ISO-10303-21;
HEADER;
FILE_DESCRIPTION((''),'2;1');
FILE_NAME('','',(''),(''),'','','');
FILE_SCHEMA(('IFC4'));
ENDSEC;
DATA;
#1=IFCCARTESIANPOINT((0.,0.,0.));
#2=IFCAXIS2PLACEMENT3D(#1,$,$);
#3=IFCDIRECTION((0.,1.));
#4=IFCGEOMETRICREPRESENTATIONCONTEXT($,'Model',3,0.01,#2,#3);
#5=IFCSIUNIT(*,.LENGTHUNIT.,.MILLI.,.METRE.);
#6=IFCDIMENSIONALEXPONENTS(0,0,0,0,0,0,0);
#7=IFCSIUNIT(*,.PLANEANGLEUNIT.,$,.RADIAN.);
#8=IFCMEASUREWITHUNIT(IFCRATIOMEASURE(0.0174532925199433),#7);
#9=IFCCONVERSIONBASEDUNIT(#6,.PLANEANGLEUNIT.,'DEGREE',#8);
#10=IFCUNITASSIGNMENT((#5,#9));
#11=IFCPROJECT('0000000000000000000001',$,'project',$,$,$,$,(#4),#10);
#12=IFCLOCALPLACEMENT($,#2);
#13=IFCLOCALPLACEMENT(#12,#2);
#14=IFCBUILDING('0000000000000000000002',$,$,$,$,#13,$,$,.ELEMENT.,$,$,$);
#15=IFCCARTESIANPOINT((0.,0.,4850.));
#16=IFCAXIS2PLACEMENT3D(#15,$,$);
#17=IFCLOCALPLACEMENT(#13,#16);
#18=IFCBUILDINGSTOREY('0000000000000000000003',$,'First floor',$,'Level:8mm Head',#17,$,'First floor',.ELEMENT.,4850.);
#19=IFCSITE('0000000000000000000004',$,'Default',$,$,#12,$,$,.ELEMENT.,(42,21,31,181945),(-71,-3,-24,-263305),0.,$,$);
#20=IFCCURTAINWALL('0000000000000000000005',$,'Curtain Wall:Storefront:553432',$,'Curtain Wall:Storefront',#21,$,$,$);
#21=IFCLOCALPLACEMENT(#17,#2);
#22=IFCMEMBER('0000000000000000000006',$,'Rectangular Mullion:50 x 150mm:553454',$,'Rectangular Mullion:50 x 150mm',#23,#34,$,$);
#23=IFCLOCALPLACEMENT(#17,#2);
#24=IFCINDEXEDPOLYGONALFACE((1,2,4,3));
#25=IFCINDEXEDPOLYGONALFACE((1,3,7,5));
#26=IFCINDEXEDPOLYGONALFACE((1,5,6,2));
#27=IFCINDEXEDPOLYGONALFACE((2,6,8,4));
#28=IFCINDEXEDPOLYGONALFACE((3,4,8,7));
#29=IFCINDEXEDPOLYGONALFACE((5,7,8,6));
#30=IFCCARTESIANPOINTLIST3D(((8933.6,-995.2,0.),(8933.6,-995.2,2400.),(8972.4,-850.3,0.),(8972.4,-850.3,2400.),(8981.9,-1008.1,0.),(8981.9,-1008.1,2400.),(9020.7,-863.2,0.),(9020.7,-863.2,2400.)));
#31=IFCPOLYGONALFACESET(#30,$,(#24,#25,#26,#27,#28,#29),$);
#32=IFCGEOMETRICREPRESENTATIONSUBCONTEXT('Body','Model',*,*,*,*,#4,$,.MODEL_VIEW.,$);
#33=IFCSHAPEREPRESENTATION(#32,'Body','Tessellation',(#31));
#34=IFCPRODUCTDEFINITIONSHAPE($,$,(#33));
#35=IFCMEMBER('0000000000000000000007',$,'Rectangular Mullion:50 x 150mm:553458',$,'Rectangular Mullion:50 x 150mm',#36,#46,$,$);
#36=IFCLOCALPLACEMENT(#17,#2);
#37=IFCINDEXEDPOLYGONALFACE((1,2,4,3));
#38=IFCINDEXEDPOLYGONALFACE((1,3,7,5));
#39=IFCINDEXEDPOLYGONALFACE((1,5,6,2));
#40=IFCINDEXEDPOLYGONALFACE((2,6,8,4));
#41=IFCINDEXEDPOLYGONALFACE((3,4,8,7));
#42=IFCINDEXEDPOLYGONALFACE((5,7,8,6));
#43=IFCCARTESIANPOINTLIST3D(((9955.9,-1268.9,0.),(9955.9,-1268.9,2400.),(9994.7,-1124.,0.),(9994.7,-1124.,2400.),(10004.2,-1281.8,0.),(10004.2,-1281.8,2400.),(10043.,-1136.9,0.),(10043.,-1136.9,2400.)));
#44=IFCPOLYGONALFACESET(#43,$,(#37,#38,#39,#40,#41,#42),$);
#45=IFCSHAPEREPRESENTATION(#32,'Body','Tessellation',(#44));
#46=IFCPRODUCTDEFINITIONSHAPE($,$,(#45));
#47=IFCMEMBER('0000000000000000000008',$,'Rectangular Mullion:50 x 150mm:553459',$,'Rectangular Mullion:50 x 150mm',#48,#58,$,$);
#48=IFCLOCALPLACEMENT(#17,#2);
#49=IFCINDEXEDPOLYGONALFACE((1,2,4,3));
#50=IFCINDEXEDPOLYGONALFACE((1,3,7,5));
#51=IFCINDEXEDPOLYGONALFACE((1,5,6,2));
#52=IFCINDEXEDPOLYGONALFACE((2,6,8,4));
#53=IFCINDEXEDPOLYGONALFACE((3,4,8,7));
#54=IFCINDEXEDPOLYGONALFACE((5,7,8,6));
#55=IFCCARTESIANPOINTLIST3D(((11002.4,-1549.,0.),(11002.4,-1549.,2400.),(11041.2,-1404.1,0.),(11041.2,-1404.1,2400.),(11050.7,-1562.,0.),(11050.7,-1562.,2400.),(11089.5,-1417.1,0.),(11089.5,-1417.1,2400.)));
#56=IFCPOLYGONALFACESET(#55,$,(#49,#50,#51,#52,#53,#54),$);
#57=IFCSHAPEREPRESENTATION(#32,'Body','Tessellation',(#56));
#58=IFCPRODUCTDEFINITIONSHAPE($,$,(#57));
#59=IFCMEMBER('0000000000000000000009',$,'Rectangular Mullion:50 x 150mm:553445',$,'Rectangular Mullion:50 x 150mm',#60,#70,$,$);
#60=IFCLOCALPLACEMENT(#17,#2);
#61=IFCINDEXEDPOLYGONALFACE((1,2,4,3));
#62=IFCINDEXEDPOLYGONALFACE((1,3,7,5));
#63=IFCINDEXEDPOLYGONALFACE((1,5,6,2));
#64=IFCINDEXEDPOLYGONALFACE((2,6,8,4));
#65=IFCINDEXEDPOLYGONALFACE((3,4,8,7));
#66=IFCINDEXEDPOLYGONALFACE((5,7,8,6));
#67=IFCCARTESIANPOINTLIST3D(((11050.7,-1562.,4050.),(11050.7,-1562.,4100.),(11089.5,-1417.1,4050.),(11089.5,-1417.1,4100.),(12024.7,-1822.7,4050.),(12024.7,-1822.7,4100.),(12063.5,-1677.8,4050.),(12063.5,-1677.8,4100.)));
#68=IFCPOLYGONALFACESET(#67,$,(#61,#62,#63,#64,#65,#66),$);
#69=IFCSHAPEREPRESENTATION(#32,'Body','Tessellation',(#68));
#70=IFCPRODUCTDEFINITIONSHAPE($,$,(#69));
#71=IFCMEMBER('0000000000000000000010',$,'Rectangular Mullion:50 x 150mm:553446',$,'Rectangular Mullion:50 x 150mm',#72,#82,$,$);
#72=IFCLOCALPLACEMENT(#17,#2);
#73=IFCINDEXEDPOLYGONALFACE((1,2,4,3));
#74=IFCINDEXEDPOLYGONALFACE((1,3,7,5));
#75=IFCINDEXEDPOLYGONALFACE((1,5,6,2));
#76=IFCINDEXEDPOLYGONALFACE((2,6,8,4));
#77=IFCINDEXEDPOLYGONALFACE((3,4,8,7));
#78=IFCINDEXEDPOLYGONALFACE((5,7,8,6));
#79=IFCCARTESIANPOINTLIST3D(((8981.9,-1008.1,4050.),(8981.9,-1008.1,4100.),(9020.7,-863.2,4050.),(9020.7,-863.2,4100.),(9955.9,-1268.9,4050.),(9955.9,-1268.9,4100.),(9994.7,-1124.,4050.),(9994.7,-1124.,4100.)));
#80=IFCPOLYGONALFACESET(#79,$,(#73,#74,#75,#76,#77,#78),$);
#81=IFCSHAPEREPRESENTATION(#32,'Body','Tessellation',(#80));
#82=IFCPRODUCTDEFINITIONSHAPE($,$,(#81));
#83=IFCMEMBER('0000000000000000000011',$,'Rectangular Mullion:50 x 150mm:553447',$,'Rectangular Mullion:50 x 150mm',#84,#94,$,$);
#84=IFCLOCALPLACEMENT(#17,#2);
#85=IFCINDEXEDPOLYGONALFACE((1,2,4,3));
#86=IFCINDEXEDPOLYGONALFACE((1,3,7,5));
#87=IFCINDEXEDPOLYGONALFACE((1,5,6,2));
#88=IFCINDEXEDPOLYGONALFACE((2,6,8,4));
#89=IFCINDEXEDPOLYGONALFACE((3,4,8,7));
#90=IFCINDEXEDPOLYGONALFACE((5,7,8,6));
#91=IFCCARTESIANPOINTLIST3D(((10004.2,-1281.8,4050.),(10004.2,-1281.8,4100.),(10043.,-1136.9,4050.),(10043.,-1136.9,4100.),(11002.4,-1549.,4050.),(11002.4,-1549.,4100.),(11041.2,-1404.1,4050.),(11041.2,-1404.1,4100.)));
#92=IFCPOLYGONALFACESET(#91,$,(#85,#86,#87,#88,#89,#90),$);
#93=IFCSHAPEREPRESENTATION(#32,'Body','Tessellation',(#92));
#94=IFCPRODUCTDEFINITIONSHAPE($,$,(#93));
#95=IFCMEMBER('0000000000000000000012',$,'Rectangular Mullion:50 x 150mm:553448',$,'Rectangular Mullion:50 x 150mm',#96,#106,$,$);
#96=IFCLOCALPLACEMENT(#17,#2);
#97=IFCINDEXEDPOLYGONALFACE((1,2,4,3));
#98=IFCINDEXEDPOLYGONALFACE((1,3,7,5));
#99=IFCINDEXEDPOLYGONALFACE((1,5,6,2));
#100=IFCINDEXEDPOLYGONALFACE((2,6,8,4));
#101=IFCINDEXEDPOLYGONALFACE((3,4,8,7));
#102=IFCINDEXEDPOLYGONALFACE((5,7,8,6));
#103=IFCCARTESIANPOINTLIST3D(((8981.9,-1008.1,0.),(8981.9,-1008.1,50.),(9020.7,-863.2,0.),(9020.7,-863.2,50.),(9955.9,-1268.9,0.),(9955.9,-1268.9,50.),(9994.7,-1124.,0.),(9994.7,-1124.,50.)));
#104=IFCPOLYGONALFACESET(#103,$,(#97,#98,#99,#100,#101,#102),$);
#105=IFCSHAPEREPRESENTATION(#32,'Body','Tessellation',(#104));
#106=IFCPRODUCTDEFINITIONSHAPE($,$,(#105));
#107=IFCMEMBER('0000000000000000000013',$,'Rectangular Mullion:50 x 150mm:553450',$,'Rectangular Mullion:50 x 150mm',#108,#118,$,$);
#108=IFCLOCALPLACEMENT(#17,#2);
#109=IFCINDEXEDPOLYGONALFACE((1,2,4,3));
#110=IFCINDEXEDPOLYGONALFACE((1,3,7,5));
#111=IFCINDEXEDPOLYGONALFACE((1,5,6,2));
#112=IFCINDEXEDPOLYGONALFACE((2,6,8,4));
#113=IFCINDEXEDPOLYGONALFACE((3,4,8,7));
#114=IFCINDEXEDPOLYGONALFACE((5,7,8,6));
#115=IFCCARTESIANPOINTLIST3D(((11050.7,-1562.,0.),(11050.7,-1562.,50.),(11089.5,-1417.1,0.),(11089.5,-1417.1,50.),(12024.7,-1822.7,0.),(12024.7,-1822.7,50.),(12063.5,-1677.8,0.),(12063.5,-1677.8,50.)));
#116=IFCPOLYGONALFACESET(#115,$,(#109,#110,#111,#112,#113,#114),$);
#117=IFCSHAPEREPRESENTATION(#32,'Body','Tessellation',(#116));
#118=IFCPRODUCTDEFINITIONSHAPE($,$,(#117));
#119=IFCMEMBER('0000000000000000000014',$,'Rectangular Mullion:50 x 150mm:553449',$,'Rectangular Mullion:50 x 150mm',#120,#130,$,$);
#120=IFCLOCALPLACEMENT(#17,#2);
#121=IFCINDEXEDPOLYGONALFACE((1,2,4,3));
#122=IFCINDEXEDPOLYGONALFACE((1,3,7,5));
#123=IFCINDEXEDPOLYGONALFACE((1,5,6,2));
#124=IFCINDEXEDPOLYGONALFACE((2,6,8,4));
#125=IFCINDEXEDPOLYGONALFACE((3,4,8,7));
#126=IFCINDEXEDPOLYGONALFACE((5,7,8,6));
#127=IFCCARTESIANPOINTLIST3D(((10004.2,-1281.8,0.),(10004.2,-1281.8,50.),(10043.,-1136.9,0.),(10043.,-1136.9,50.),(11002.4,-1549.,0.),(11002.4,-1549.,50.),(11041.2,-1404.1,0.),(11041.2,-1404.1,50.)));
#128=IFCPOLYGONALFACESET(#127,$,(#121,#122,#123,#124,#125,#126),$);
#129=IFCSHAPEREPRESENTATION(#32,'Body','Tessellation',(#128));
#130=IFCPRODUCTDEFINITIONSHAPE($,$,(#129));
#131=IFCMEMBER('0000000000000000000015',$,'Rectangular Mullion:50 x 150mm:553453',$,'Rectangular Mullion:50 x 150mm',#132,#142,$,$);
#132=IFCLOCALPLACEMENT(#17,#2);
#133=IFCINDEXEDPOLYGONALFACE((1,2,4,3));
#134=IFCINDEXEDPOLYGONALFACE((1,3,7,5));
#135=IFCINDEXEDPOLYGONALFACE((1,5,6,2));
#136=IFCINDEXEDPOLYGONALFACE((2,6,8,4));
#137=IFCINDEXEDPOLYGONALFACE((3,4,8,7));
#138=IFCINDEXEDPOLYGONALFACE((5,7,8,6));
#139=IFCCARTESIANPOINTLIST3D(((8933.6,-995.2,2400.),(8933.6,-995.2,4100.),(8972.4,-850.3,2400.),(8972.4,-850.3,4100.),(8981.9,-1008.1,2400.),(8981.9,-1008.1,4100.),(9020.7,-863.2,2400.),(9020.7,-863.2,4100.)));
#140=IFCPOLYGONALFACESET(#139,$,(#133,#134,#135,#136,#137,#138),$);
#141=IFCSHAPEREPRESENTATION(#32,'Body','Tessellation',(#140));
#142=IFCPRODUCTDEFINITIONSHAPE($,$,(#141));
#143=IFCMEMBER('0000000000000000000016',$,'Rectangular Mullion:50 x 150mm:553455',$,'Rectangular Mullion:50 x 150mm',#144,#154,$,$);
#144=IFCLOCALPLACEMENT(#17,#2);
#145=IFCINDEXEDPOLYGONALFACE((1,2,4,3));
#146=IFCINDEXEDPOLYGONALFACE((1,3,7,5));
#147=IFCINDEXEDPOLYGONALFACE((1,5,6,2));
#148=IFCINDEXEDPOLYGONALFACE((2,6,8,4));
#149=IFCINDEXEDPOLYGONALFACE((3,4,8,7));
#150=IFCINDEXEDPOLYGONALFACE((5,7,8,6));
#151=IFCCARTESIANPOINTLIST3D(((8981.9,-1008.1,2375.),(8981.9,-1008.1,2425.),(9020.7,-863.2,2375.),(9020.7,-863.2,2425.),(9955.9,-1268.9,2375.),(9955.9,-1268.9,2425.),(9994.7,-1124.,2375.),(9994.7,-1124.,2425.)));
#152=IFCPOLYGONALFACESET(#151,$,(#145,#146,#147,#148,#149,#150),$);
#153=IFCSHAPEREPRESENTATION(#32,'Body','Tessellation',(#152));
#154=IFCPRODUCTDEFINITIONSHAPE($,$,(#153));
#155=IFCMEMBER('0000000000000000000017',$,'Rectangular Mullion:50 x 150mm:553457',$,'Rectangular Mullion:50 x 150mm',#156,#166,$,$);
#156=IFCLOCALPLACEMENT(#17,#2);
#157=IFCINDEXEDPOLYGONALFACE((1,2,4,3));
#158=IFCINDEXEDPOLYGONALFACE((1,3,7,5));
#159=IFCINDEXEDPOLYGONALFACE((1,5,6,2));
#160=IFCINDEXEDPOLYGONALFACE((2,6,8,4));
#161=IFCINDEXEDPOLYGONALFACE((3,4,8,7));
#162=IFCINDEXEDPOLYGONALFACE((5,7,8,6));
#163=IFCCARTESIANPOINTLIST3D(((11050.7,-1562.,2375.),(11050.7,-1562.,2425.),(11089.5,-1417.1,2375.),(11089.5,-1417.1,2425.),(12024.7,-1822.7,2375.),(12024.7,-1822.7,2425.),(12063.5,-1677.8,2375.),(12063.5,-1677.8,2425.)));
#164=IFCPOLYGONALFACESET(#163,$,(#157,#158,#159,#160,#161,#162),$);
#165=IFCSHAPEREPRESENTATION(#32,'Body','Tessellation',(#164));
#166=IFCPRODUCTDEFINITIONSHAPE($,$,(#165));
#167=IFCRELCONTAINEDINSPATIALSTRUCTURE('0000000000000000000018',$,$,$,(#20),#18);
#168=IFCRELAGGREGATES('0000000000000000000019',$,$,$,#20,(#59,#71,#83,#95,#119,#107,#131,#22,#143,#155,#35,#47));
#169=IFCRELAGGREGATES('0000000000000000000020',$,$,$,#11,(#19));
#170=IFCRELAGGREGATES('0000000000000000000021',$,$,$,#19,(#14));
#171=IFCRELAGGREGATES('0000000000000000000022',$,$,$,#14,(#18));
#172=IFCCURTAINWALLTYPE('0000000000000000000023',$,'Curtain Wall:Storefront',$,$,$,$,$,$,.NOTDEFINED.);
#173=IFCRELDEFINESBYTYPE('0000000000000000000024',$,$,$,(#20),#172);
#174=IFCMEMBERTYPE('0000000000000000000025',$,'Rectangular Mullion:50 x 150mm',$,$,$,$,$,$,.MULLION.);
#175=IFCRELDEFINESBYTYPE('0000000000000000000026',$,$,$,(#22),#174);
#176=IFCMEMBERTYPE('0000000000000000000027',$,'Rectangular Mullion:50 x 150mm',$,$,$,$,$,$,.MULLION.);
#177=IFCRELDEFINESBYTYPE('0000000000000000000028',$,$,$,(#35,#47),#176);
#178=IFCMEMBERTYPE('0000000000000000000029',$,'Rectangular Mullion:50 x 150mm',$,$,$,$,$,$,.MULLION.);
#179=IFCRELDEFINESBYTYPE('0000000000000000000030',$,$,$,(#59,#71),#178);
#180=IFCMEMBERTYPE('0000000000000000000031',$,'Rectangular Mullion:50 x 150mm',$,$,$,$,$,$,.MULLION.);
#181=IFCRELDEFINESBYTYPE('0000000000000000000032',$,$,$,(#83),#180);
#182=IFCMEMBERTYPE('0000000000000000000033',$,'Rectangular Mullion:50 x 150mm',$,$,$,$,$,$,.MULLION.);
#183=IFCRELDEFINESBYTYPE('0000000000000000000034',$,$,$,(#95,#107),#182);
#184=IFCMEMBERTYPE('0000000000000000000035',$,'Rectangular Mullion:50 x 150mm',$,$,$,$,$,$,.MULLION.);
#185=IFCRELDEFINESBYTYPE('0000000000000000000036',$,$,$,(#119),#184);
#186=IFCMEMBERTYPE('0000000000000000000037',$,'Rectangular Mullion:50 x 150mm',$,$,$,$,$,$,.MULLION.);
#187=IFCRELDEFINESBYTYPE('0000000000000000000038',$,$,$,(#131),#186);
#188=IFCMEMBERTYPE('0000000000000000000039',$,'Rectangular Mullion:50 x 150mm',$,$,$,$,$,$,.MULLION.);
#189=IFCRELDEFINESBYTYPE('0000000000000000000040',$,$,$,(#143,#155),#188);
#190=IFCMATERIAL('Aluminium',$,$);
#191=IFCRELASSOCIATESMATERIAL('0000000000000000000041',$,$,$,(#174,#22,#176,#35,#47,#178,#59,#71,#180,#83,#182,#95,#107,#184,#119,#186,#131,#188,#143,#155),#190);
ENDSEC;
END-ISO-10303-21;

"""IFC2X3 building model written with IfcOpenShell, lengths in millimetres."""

from ifc_helpers import new_model, entity, si_unit, converted_unit, direction, frame, frame_2d, origin, origin_2d_with_axis, place, context, subcontext, project, spatial, rectangle, extrude, source, transform, mapped, material, type_object, type_shapes, element, aggregate, save


model = new_model("IFC2X3")

# Units and contexts
model_context = context("Model", 3, precision=0.01, world=origin(), true_north=direction((0.0, 1.0)))
body_context = subcontext(model_context, "Body", "Model", "MODEL_VIEW")
ifc_project = project(units=[si_unit("LENGTHUNIT", "METRE", prefix="MILLI"), converted_unit("PLANEANGLEUNIT", "DEGREE", entity("IfcRatioMeasure", 0.0174532925199433), si_unit("PLANEANGLEUNIT", "RADIAN"), dimensions=[0, 0, 0, 0, 0, 0, 0])], contexts=[model_context])

# Site, building, storey
site_placement = place(None, origin())
site = spatial("IfcSite", under=ifc_project, at=site_placement, Name="Default", CompositionType="ELEMENT", RefLatitude=(42, 21, 31, 181945), RefLongitude=(-71, -3, -24, -263305), RefElevation=0.0)
building_placement = place(site_placement, origin())
building = spatial("IfcBuilding", under=site, at=building_placement, CompositionType="ELEMENT")
storey_placement = place(building_placement, frame((0.0, 0.0, 4850.0)))
storey = spatial("IfcBuildingStorey", under=building, at=storey_placement, Name="First floor", ObjectType="Level:8mm Head", LongName="First floor", CompositionType="ELEMENT", Elevation=4850.0)

# Curtain wall, members
curtain_wall_type = type_object("IfcCurtainWallType", Name="Curtain Wall:Storefront", PredefinedType="NOTDEFINED")
curtain_wall_placement = place(storey_placement, frame((0.0, 0.0, -4850.0)))
curtain_wall = element("IfcCurtainWall", 1, at=curtain_wall_placement, inside=storey, type_object=curtain_wall_type, Name="Curtain Wall:Storefront:553432", ObjectType="Curtain Wall:Storefront")
ifc_material_1 = material(Name="Aluminium")
member_type_1 = type_object("IfcMemberType", Name="Rectangular Mullion:50 x 150mm", PredefinedType="MULLION", material=ifc_material_1)
shared_shape_1 = source(origin(), body_context, "Body", "SweptSolid", [
    extrude(rectangle(XDim=150.0, YDim=50.0, at=origin_2d_with_axis()), frame((-25.0, 0.0, -2400.0), z_axis=(0.0, 0.0, 1.0), x_axis=(0.0, -1.0, 0.0)), (0.0, 0.0, 1.0), 2400.0),
])
type_shapes(member_type_1, [shared_shape_1])
member_1_placement = place(storey_placement, frame((8953.0, -922.7, 2400.0), z_axis=(0.0, 0.0, 1.0), x_axis=(-0.965983, 0.258606, 0.0)))
member_1 = element("IfcMember", 2, at=member_1_placement, type_object=member_type_1, material=ifc_material_1, Name="Rectangular Mullion:50 x 150mm:553454", ObjectType="Rectangular Mullion:50 x 150mm", context=body_context, shape_type="MappedRepresentation", body=[
    mapped(shared_shape_1, transform((0.0, 0.0, 0.0), scale=1.0)),
])
member_type_2 = type_object("IfcMemberType", Name="Rectangular Mullion:50 x 150mm", PredefinedType="MULLION", material=ifc_material_1)
shared_shape_2 = source(origin(), body_context, "Body", "SweptSolid", [
    extrude(rectangle(XDim=150.0, YDim=50.0, at=origin_2d_with_axis()), frame((0.0, 0.0, -2400.0), z_axis=(0.0, 0.0, 1.0), x_axis=(0.0, -1.0, 0.0)), (0.0, 0.0, 1.0), 2400.0),
])
type_shapes(member_type_2, [shared_shape_2])
member_2_placement = place(storey_placement, frame((9999.4, -1202.9, 0.0), z_axis=(0.0, 0.0, -1.0), x_axis=(0.965983, -0.258606, 0.0)))
member_2 = element("IfcMember", 3, at=member_2_placement, type_object=member_type_2, material=ifc_material_1, Name="Rectangular Mullion:50 x 150mm:553458", ObjectType="Rectangular Mullion:50 x 150mm", context=body_context, shape_type="MappedRepresentation", body=[
    mapped(shared_shape_2, transform((0.0, 0.0, 0.0), scale=1.0)),
])
member_3_placement = place(storey_placement, frame((11045.9, -1483.1, 0.0), z_axis=(0.0, 0.0, -1.0), x_axis=(0.965983, -0.258606, 0.0)))
member_3 = element("IfcMember", 4, at=member_3_placement, type_object=member_type_2, material=ifc_material_1, Name="Rectangular Mullion:50 x 150mm:553459", ObjectType="Rectangular Mullion:50 x 150mm", context=body_context, shape_type="MappedRepresentation", body=[
    mapped(shared_shape_2, transform((0.0, 0.0, 0.0), scale=1.0)),
])
member_type_3 = type_object("IfcMemberType", Name="Rectangular Mullion:50 x 150mm", PredefinedType="MULLION", material=ifc_material_1)
shared_shape_3 = source(origin(), body_context, "Body", "SweptSolid", [
    extrude(rectangle(XDim=150.0, YDim=50.0, at=origin_2d_with_axis()), frame((-25.0, 0.0, -1008.3), z_axis=(0.0, 0.0, 1.0), x_axis=(0.0, -1.0, 0.0)), (0.0, 0.0, 1.0), 1008.3),
])
type_shapes(member_type_3, [shared_shape_3])
member_4_placement = place(storey_placement, frame((12044.1, -1750.3, 4100.0), z_axis=(0.965983, -0.258606, 0.0), x_axis=(0.0, 0.0, 1.0)))
member_4 = element("IfcMember", 5, at=member_4_placement, type_object=member_type_3, material=ifc_material_1, Name="Rectangular Mullion:50 x 150mm:553445", ObjectType="Rectangular Mullion:50 x 150mm", context=body_context, shape_type="MappedRepresentation", body=[
    mapped(shared_shape_3, transform((0.0, 0.0, 0.0), scale=1.0)),
])
member_5_placement = place(storey_placement, frame((9975.3, -1196.4, 4100.0), z_axis=(0.965983, -0.258606, 0.0), x_axis=(0.0, 0.0, 1.0)))
member_5 = element("IfcMember", 6, at=member_5_placement, type_object=member_type_3, material=ifc_material_1, Name="Rectangular Mullion:50 x 150mm:553446", ObjectType="Rectangular Mullion:50 x 150mm", context=body_context, shape_type="MappedRepresentation", body=[
    mapped(shared_shape_3, transform((0.0, 0.0, 0.0), scale=1.0)),
])
member_type_4 = type_object("IfcMemberType", Name="Rectangular Mullion:50 x 150mm", PredefinedType="MULLION", material=ifc_material_1)
shared_shape_4 = source(origin(), body_context, "Body", "SweptSolid", [
    extrude(rectangle(XDim=150.0, YDim=50.0, at=frame_2d((0.0, 0.0), x_axis=(1.0, 0.0))), frame((-25.0, 0.0, -1033.3), z_axis=(0.0, 0.0, 1.0), x_axis=(0.0, -1.0, 0.0)), (0.0, 0.0, 1.0), 1033.3),
])
type_shapes(member_type_4, [shared_shape_4])
member_6_placement = place(storey_placement, frame((11021.8, -1476.6, 4100.0), z_axis=(0.965983, -0.258606, 0.0), x_axis=(0.0, 0.0, 1.0)))
member_6 = element("IfcMember", 7, at=member_6_placement, type_object=member_type_4, material=ifc_material_1, Name="Rectangular Mullion:50 x 150mm:553447", ObjectType="Rectangular Mullion:50 x 150mm", context=body_context, shape_type="MappedRepresentation", body=[
    mapped(shared_shape_4, transform((0.0, 0.0, 0.0), scale=1.0)),
])
member_type_5 = type_object("IfcMemberType", Name="Rectangular Mullion:50 x 150mm", PredefinedType="MULLION", material=ifc_material_1)
shared_shape_5 = source(origin(), body_context, "Body", "SweptSolid", [
    extrude(rectangle(XDim=150.0, YDim=50.0, at=frame_2d((0.0, 0.0), x_axis=(1.0, 0.0))), frame((-25.0, 0.0, -1008.3), z_axis=(0.0, 0.0, 1.0), x_axis=(0.0, -1.0, 0.0)), (0.0, 0.0, 1.0), 1008.3),
])
type_shapes(member_type_5, [shared_shape_5])
member_7_placement = place(storey_placement, frame((9001.3, -935.7, 0.0), z_axis=(-0.965983, 0.258606, 0.0), x_axis=(0.0, 0.0, -1.0)))
member_7 = element("IfcMember", 8, at=member_7_placement, type_object=member_type_5, material=ifc_material_1, Name="Rectangular Mullion:50 x 150mm:553448", ObjectType="Rectangular Mullion:50 x 150mm", context=body_context, shape_type="MappedRepresentation", body=[
    mapped(shared_shape_5, transform((0.0, 0.0, 0.0), scale=1.0)),
])
member_8_placement = place(storey_placement, frame((11070.1, -1489.5, 0.0), z_axis=(-0.965983, 0.258606, 0.0), x_axis=(0.0, 0.0, -1.0)))
member_8 = element("IfcMember", 9, at=member_8_placement, type_object=member_type_5, material=ifc_material_1, Name="Rectangular Mullion:50 x 150mm:553450", ObjectType="Rectangular Mullion:50 x 150mm", context=body_context, shape_type="MappedRepresentation", body=[
    mapped(shared_shape_5, transform((0.0, 0.0, 0.0), scale=1.0)),
])
member_type_6 = type_object("IfcMemberType", Name="Rectangular Mullion:50 x 150mm", PredefinedType="MULLION", material=ifc_material_1)
shared_shape_6 = source(origin(), body_context, "Body", "SweptSolid", [
    extrude(rectangle(XDim=150.0, YDim=50.0, at=frame_2d((0.0, 0.0), x_axis=(1.0, 0.0))), frame((-25.0, 0.0, -1033.3), z_axis=(0.0, 0.0, 1.0), x_axis=(0.0, -1.0, 0.0)), (0.0, 0.0, 1.0), 1033.3),
])
type_shapes(member_type_6, [shared_shape_6])
member_9_placement = place(storey_placement, frame((10023.6, -1209.4, 0.0), z_axis=(-0.965983, 0.258606, 0.0), x_axis=(0.0, 0.0, -1.0)))
member_9 = element("IfcMember", 10, at=member_9_placement, type_object=member_type_6, material=ifc_material_1, Name="Rectangular Mullion:50 x 150mm:553449", ObjectType="Rectangular Mullion:50 x 150mm", context=body_context, shape_type="MappedRepresentation", body=[
    mapped(shared_shape_6, transform((0.0, 0.0, 0.0), scale=1.0)),
])
member_type_7 = type_object("IfcMemberType", Name="Rectangular Mullion:50 x 150mm", PredefinedType="MULLION", material=ifc_material_1)
shared_shape_7 = source(origin(), body_context, "Body", "SweptSolid", [
    extrude(rectangle(XDim=150.0, YDim=50.0, at=origin_2d_with_axis()), frame((-25.0, 0.0, -1700.0), z_axis=(0.0, 0.0, 1.0), x_axis=(0.0, -1.0, 0.0)), (0.0, 0.0, 1.0), 1700.0),
])
type_shapes(member_type_7, [shared_shape_7])
member_10_placement = place(storey_placement, frame((8953.0, -922.7, 4100.0), z_axis=(0.0, 0.0, 1.0), x_axis=(-0.965983, 0.258606, 0.0)))
member_10 = element("IfcMember", 11, at=member_10_placement, type_object=member_type_7, material=ifc_material_1, Name="Rectangular Mullion:50 x 150mm:553453", ObjectType="Rectangular Mullion:50 x 150mm", context=body_context, shape_type="MappedRepresentation", body=[
    mapped(shared_shape_7, transform((0.0, 0.0, 0.0), scale=1.0)),
])
member_type_8 = type_object("IfcMemberType", Name="Rectangular Mullion:50 x 150mm", PredefinedType="MULLION", material=ifc_material_1)
shared_shape_8 = source(origin(), body_context, "Body", "SweptSolid", [
    extrude(rectangle(XDim=150.0, YDim=50.0, at=frame_2d((0.0, 0.0), x_axis=(1.0, 0.0))), frame((0.0, 0.0, -1008.3), z_axis=(0.0, 0.0, 1.0), x_axis=(0.0, -1.0, 0.0)), (0.0, 0.0, 1.0), 1008.3),
])
type_shapes(member_type_8, [shared_shape_8])
member_11_placement = place(storey_placement, frame((9975.3, -1196.4, 2400.0), z_axis=(0.965983, -0.258606, 0.0), x_axis=(0.0, 0.0, 1.0)))
member_11 = element("IfcMember", 12, at=member_11_placement, type_object=member_type_8, material=ifc_material_1, Name="Rectangular Mullion:50 x 150mm:553455", ObjectType="Rectangular Mullion:50 x 150mm", context=body_context, shape_type="MappedRepresentation", body=[
    mapped(shared_shape_8, transform((0.0, 0.0, 0.0), scale=1.0)),
])
member_12_placement = place(storey_placement, frame((12044.1, -1750.3, 2400.0), z_axis=(0.965983, -0.258606, 0.0), x_axis=(0.0, 0.0, 1.0)))
member_12 = element("IfcMember", 13, at=member_12_placement, type_object=member_type_8, material=ifc_material_1, Name="Rectangular Mullion:50 x 150mm:553457", ObjectType="Rectangular Mullion:50 x 150mm", context=body_context, shape_type="MappedRepresentation", body=[
    mapped(shared_shape_8, transform((0.0, 0.0, 0.0), scale=1.0)),
])
aggregate(curtain_wall, [member_4, member_5, member_6, member_7, member_9, member_8, member_10, member_1, member_11, member_12, member_2, member_3])

save(model, "model.ifc")
